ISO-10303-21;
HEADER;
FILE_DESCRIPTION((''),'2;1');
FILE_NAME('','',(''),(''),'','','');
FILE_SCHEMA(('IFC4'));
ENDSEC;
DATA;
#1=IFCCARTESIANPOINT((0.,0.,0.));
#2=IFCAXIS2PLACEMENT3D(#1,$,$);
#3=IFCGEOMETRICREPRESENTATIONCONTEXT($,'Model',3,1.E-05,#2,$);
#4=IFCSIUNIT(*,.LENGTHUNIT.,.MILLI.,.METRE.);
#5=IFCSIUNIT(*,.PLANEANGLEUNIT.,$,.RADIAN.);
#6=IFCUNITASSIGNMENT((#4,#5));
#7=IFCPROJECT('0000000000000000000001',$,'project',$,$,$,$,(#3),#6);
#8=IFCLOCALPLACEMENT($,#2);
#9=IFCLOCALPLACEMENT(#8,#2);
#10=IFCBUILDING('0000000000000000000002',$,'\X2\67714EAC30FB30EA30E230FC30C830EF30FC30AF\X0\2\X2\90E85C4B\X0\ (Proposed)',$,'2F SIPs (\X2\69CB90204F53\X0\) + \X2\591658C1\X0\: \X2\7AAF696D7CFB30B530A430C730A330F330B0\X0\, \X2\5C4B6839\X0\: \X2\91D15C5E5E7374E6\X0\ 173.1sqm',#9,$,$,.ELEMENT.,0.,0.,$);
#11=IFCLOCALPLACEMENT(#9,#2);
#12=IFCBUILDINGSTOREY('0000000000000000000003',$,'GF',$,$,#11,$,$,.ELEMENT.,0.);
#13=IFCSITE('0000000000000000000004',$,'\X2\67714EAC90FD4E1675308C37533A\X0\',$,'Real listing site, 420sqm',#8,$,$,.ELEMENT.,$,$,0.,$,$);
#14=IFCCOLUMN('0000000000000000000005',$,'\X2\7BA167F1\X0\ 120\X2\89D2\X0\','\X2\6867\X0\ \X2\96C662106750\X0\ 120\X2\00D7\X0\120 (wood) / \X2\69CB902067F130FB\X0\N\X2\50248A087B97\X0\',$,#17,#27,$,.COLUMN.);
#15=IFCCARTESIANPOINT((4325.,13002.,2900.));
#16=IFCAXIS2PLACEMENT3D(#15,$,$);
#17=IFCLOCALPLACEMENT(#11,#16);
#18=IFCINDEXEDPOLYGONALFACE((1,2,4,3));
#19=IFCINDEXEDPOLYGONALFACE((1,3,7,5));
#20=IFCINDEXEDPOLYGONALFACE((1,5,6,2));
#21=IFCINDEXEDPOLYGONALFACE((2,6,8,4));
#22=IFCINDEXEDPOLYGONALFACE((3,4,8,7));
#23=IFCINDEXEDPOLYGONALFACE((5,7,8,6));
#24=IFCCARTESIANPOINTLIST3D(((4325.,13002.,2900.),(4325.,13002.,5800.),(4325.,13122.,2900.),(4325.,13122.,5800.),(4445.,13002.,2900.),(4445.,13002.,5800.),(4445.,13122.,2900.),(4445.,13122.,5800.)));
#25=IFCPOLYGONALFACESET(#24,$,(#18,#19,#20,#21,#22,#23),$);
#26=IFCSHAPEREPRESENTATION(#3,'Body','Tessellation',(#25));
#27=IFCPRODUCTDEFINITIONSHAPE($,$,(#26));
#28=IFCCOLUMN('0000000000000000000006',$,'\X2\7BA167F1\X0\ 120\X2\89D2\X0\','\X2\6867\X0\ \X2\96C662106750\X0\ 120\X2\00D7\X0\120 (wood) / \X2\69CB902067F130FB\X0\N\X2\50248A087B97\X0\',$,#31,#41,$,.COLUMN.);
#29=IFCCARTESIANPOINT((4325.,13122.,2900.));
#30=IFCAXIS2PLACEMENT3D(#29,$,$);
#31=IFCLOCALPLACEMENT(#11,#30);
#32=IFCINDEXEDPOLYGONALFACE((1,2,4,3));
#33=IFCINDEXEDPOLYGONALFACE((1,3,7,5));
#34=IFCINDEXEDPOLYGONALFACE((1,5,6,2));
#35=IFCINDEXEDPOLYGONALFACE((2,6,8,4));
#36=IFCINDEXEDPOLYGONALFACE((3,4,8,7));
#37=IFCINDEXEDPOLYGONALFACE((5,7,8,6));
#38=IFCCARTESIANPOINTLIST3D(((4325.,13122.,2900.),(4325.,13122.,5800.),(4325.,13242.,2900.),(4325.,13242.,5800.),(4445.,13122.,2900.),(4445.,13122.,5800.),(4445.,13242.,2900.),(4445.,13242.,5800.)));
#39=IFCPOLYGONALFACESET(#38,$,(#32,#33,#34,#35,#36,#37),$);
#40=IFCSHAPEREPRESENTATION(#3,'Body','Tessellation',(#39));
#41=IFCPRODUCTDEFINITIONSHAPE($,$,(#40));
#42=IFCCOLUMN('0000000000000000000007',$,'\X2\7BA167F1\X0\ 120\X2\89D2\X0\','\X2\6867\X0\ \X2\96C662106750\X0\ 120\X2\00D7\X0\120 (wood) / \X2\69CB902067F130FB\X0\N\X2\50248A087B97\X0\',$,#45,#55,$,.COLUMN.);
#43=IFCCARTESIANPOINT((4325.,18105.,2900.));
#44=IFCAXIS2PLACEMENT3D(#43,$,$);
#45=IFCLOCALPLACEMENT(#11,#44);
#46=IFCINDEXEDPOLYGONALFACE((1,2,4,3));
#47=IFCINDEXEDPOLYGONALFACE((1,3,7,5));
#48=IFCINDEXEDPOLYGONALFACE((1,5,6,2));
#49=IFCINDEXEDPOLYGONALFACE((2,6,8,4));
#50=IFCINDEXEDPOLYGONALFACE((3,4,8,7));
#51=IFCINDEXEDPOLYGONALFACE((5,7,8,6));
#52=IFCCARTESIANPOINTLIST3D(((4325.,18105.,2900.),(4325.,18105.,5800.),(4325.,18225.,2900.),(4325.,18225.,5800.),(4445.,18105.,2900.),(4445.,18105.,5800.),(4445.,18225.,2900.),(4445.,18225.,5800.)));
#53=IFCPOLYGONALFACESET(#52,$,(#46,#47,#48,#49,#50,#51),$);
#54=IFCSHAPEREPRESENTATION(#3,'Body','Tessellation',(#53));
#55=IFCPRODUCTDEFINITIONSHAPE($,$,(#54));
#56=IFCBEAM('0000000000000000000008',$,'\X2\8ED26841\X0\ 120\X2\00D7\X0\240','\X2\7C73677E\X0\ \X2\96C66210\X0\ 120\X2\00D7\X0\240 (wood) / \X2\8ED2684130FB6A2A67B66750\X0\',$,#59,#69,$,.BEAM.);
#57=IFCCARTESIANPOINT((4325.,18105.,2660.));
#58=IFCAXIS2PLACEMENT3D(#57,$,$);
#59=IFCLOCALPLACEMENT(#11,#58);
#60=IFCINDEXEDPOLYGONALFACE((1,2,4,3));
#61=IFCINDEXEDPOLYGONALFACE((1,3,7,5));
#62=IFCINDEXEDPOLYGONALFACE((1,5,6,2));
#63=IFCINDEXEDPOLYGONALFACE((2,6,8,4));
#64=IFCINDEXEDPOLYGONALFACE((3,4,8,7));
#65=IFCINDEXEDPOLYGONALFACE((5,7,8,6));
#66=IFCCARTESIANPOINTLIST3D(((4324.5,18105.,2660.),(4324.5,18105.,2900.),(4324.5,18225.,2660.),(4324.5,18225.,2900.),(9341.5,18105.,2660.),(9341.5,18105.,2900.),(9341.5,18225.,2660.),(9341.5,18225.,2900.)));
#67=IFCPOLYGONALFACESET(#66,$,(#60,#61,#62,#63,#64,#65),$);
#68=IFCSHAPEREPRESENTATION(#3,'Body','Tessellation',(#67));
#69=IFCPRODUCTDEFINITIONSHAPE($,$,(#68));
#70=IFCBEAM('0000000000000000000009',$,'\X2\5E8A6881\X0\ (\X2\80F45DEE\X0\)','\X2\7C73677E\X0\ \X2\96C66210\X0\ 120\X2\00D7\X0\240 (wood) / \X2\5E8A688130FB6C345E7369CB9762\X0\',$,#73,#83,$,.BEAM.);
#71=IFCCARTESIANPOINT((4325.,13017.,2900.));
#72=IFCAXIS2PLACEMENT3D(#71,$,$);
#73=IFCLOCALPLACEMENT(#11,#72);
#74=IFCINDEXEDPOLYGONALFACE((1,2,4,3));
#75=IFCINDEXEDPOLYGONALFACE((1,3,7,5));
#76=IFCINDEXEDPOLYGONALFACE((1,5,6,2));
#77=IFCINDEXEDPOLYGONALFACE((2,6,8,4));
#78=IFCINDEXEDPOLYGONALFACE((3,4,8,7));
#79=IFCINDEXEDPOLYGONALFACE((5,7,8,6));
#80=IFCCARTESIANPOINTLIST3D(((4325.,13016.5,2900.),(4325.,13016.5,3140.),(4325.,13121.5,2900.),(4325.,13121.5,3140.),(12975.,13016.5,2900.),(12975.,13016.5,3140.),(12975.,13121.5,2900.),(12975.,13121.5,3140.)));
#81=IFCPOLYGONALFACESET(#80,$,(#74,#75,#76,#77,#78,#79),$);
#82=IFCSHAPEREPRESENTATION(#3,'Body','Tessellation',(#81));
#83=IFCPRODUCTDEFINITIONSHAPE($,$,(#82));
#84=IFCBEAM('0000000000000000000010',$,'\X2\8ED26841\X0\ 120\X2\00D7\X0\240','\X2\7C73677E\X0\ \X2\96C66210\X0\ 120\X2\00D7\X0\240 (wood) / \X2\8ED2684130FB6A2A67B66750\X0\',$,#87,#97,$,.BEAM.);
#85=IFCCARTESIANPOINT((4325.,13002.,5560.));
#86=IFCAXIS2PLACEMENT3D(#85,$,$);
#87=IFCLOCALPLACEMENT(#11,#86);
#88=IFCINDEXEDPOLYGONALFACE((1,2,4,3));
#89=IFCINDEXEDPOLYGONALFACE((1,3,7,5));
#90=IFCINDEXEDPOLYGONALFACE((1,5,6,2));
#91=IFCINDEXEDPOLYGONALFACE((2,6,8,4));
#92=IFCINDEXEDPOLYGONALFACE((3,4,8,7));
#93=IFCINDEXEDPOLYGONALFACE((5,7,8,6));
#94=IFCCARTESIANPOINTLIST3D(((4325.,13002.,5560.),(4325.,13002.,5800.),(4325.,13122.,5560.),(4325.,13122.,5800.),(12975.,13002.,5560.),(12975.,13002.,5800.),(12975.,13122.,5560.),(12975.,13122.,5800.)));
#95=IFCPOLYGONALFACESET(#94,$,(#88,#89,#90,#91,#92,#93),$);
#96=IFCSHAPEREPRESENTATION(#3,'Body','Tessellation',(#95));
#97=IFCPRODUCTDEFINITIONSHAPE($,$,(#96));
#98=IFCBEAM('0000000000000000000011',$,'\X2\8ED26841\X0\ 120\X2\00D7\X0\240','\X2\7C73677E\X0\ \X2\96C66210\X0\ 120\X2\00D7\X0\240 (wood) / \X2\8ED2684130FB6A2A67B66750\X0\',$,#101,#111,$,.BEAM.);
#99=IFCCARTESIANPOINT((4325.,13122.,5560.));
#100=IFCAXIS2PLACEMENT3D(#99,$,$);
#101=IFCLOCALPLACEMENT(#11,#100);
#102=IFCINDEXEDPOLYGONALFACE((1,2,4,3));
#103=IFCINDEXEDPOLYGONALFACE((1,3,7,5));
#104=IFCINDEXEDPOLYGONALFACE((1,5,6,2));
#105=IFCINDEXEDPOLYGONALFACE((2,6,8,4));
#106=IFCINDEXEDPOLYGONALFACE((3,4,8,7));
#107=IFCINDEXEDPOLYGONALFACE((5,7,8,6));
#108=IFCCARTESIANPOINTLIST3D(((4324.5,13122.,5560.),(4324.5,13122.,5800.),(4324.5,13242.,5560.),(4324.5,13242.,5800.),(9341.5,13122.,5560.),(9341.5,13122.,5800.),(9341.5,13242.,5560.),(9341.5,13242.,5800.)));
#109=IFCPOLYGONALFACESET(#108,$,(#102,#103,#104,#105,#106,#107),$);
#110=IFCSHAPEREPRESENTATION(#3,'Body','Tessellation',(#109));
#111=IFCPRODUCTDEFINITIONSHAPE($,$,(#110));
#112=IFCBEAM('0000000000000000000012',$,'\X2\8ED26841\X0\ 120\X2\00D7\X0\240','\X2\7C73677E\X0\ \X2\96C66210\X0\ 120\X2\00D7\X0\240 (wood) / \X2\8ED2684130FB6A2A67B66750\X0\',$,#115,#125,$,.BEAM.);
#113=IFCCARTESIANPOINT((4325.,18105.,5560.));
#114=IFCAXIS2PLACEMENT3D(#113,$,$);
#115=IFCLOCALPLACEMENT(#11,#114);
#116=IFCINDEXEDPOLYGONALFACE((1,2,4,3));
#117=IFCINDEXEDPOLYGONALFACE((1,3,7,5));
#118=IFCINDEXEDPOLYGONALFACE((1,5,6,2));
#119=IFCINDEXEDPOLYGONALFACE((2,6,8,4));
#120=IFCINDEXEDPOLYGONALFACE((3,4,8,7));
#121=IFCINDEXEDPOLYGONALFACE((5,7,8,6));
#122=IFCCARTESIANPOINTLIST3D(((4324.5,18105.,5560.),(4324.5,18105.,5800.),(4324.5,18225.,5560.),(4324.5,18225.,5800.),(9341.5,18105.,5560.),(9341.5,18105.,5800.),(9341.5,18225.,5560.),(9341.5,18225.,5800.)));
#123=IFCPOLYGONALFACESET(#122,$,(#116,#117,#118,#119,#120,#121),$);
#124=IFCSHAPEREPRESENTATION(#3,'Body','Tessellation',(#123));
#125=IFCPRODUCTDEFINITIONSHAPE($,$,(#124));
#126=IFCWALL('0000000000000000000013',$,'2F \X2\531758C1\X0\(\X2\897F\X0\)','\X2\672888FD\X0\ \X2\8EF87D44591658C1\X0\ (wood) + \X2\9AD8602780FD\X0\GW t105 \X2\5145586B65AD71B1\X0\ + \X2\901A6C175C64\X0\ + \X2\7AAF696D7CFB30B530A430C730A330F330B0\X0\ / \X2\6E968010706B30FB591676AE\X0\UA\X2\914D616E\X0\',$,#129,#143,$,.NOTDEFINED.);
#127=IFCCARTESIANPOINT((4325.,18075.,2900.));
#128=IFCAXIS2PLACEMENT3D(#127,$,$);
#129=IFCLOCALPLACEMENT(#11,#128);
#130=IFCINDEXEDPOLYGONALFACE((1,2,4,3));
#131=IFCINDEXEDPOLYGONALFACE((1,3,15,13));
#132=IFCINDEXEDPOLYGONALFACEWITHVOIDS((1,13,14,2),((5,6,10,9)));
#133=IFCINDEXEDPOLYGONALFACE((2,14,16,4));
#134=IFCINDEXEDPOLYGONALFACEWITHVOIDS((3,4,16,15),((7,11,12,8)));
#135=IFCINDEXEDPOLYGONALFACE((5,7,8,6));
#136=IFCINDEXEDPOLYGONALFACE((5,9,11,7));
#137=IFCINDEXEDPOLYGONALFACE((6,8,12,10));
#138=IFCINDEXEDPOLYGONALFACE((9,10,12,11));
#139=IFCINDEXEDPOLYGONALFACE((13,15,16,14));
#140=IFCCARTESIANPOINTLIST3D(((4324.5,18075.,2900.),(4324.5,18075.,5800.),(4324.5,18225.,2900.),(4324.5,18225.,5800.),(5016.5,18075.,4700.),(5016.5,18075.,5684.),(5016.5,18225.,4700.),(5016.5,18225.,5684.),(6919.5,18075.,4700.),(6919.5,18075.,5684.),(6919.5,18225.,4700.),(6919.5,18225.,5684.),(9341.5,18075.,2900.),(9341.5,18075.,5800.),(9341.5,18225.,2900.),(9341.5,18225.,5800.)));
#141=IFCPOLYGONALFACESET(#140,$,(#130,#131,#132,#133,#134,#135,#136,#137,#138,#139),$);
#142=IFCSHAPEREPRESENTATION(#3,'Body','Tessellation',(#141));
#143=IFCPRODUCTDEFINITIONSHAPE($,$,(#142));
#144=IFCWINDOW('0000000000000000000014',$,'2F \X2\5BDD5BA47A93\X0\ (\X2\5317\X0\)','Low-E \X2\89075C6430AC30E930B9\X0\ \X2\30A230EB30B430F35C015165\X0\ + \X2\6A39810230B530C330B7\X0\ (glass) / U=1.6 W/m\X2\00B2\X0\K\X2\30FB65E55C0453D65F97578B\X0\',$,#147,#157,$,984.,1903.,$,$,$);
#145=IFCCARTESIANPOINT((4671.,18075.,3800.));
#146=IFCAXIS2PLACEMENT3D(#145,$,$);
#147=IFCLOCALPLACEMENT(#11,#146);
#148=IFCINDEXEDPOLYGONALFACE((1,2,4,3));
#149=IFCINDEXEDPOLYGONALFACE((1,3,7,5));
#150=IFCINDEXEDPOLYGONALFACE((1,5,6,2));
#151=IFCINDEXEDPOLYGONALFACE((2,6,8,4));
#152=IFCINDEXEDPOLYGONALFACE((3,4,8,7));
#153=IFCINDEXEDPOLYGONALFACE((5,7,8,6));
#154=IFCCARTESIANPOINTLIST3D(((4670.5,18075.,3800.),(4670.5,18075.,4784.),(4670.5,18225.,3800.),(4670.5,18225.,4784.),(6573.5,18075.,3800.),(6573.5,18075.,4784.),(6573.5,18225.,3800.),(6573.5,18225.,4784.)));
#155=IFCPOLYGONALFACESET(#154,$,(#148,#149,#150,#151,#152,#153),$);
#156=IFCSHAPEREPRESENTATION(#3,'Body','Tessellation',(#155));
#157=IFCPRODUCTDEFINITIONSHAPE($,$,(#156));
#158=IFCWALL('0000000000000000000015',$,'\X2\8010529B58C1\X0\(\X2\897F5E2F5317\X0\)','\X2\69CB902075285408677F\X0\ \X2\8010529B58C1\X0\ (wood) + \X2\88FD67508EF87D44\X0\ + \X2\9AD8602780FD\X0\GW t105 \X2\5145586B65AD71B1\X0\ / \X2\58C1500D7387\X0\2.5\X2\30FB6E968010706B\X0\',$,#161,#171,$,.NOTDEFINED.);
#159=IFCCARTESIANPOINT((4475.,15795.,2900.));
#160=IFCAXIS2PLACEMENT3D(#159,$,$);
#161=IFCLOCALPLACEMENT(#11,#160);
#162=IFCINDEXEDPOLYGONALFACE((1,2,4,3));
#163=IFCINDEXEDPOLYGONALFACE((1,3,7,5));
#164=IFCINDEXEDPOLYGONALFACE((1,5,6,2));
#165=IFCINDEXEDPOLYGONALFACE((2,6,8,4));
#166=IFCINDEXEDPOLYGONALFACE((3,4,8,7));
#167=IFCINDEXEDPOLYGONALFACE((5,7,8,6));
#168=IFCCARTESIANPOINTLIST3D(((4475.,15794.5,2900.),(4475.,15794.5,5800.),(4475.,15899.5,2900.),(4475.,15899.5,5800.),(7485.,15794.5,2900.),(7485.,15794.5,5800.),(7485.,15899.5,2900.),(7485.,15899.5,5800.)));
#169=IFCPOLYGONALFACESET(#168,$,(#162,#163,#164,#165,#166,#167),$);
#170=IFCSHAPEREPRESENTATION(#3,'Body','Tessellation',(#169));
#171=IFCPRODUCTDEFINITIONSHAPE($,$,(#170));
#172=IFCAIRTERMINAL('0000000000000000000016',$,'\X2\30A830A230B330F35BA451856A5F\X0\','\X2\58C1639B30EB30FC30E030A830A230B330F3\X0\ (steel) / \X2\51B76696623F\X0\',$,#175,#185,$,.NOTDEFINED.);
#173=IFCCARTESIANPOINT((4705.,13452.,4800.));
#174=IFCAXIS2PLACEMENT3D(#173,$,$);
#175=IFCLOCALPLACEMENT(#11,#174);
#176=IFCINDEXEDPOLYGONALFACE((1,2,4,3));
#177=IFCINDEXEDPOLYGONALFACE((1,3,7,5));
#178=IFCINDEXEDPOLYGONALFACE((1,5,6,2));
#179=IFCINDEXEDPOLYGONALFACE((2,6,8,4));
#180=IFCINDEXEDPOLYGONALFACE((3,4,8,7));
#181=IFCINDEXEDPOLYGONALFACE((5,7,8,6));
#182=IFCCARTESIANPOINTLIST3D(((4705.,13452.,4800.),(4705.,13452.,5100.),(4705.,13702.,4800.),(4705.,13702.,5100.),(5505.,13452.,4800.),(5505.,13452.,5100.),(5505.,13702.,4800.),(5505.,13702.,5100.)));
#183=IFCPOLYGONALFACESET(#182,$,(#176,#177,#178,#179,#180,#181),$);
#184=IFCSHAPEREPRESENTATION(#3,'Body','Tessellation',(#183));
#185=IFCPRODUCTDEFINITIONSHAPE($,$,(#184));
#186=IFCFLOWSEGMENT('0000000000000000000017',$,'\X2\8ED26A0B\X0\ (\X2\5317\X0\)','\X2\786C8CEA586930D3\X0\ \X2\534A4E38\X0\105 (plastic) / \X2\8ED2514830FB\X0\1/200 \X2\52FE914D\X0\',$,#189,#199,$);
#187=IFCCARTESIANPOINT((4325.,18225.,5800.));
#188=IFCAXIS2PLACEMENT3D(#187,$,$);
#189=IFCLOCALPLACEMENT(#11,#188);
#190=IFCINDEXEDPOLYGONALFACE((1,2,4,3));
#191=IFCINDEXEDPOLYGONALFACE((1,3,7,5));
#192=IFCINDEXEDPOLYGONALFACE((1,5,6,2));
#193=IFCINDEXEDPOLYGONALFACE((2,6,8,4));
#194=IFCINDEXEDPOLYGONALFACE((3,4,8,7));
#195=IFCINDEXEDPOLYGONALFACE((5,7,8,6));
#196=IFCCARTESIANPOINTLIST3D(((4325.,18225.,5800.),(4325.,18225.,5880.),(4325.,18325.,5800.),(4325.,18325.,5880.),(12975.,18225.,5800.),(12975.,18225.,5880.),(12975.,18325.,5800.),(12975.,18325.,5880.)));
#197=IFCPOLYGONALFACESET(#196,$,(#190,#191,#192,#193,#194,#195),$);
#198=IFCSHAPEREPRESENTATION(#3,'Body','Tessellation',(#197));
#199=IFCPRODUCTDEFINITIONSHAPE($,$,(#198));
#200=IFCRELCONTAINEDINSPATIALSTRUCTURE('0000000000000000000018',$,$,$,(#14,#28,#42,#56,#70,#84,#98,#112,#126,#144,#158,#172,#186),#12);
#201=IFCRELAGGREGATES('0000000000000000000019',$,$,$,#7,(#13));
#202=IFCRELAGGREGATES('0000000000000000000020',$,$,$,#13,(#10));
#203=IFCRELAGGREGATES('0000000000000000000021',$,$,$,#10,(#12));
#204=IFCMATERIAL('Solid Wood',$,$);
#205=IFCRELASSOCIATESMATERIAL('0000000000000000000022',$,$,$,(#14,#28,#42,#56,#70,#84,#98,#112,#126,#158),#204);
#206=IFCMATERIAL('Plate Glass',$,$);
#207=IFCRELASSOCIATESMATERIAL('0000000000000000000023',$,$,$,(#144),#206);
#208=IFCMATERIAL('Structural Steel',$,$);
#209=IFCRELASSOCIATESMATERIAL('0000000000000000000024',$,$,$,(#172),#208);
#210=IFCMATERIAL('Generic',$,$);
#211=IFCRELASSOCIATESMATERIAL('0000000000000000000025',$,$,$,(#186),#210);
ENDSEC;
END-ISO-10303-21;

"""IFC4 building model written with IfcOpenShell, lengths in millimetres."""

from ifc_helpers import new_model, si_unit, frame, frame_2d, origin, place, context, project, spatial, rectangle, extrude, material, element, fill, save


model = new_model("IFC4")

# Units and contexts
model_context = context("Model", 3, precision=1e-05, world=origin())
ifc_project = project(units=[si_unit("LENGTHUNIT", "METRE", prefix="MILLI"), si_unit("PLANEANGLEUNIT", "RADIAN")], contexts=[model_context])

# Site, building, storey
site_placement = place(None, origin())
site = spatial("IfcSite", under=ifc_project, at=site_placement, Name="東京都世田谷区", ObjectType="Real listing site, 420sqm", CompositionType="ELEMENT", RefElevation=0.0)
building_placement = place(site_placement, origin())
building = spatial("IfcBuilding", under=site, at=building_placement, Name="東京・リモートワーク2部屋 (Proposed)", ObjectType="2F SIPs (構造体) + 外壁: 窯業系サイディング, 屋根: 金属平瓦 173.1sqm", CompositionType="ELEMENT", ElevationOfRefHeight=0.0, ElevationOfTerrain=0.0)
storey_placement = place(building_placement, origin())
storey = spatial("IfcBuildingStorey", under=building, at=storey_placement, Name="GF", CompositionType="ELEMENT", Elevation=0.0)

# Columns
ifc_material_1 = material(Name="Solid Wood")
column_1_placement = place(storey_placement, frame((4325.0, 13002.0, 2900.0)))
element("IfcColumn", 1, at=column_1_placement, inside=storey, material=ifc_material_1, Name="管柱 120角", Description="桧 集成材 120×120 (wood) / 構造柱・N値計算", PredefinedType="COLUMN", context=model_context, shape_type="SweptSolid", body=[
    extrude(rectangle(XDim=120.0, YDim=120.0, at=frame_2d((60.0, 60.0))), frame((4325.0, 13002.0, 2900.0)), (0.0, 0.0, 1.0), 2900.0),
])
column_2_placement = place(storey_placement, frame((4325.0, 13122.0, 2900.0)))
element("IfcColumn", 2, at=column_2_placement, inside=storey, material=ifc_material_1, Name="管柱 120角", Description="桧 集成材 120×120 (wood) / 構造柱・N値計算", PredefinedType="COLUMN", context=model_context, shape_type="SweptSolid", body=[
    extrude(rectangle(XDim=120.0, YDim=120.0, at=frame_2d((60.0, 60.0))), frame((4325.0, 13122.0, 2900.0)), (0.0, 0.0, 1.0), 2900.0),
])
column_3_placement = place(storey_placement, frame((4325.0, 18105.0, 2900.0)))
element("IfcColumn", 3, at=column_3_placement, inside=storey, material=ifc_material_1, Name="管柱 120角", Description="桧 集成材 120×120 (wood) / 構造柱・N値計算", PredefinedType="COLUMN", context=model_context, shape_type="SweptSolid", body=[
    extrude(rectangle(XDim=120.0, YDim=120.0, at=frame_2d((60.0, 60.0))), frame((4325.0, 18105.0, 2900.0)), (0.0, 0.0, 1.0), 2900.0),
])

# Beams
beam_1_placement = place(storey_placement, frame((4325.0, 18105.0, 2660.0)))
element("IfcBeam", 4, at=beam_1_placement, inside=storey, material=ifc_material_1, Name="軒桁 120×240", Description="米松 集成 120×240 (wood) / 軒桁・横架材", PredefinedType="BEAM", context=model_context, shape_type="SweptSolid", body=[
    extrude(rectangle(XDim=5017.0, YDim=120.0, at=frame_2d((2508.0, 60.0))), frame((4325.0, 18105.0, 2660.0)), (0.0, 0.0, 1.0), 240.0),
])
beam_2_placement = place(storey_placement, frame((4325.0, 13017.0, 2900.0)))
element("IfcBeam", 5, at=beam_2_placement, inside=storey, material=ifc_material_1, Name="床梁 (胴差)", Description="米松 集成 120×240 (wood) / 床梁・水平構面", PredefinedType="BEAM", context=model_context, shape_type="SweptSolid", body=[
    extrude(rectangle(XDim=8650.0, YDim=105.0, at=frame_2d((4325.0, 52.0))), frame((4325.0, 13017.0, 2900.0)), (0.0, 0.0, 1.0), 240.0),
])
beam_3_placement = place(storey_placement, frame((4325.0, 13002.0, 5560.0)))
element("IfcBeam", 6, at=beam_3_placement, inside=storey, material=ifc_material_1, Name="軒桁 120×240", Description="米松 集成 120×240 (wood) / 軒桁・横架材", PredefinedType="BEAM", context=model_context, shape_type="SweptSolid", body=[
    extrude(rectangle(XDim=8650.0, YDim=120.0, at=frame_2d((4325.0, 60.0))), frame((4325.0, 13002.0, 5560.0)), (0.0, 0.0, 1.0), 240.0),
])
beam_4_placement = place(storey_placement, frame((4325.0, 13122.0, 5560.0)))
element("IfcBeam", 7, at=beam_4_placement, inside=storey, material=ifc_material_1, Name="軒桁 120×240", Description="米松 集成 120×240 (wood) / 軒桁・横架材", PredefinedType="BEAM", context=model_context, shape_type="SweptSolid", body=[
    extrude(rectangle(XDim=5017.0, YDim=120.0, at=frame_2d((2508.0, 60.0))), frame((4325.0, 13122.0, 5560.0)), (0.0, 0.0, 1.0), 240.0),
])
beam_5_placement = place(storey_placement, frame((4325.0, 18105.0, 5560.0)))
element("IfcBeam", 8, at=beam_5_placement, inside=storey, material=ifc_material_1, Name="軒桁 120×240", Description="米松 集成 120×240 (wood) / 軒桁・横架材", PredefinedType="BEAM", context=model_context, shape_type="SweptSolid", body=[
    extrude(rectangle(XDim=5017.0, YDim=120.0, at=frame_2d((2508.0, 60.0))), frame((4325.0, 18105.0, 5560.0)), (0.0, 0.0, 1.0), 240.0),
])

# Wall, opening, window
wall_1_placement = place(storey_placement, frame((4325.0, 18075.0, 2900.0)))
wall_1 = element("IfcWall", 9, at=wall_1_placement, inside=storey, material=ifc_material_1, Name="2F 北壁(西)", Description="木製 軸組外壁 (wood) + 高性能GW t105 充填断熱 + 通気層 + 窯業系サイディング / 準耐火・外皮UA配慮", PredefinedType="NOTDEFINED", context=model_context, shape_type="SweptSolid", body=[
    extrude(rectangle(XDim=5017.0, YDim=150.0, at=frame_2d((2508.0, 75.0))), frame((4325.0, 18075.0, 2900.0)), (0.0, 0.0, 1.0), 2900.0),
])
opening_placement = place(storey_placement, frame((4671.0, 18075.0, 3800.0)))
opening = element("IfcOpeningElement", 10, at=opening_placement, cuts=wall_1, PredefinedType="NOTDEFINED", context=model_context, shape_type="SweptSolid", body=[
    extrude(rectangle(XDim=1903.0, YDim=150.0, at=frame_2d((951.0, 75.0))), frame((4671.0, 18075.0, 3800.0)), (0.0, 0.0, 1.0), 984.0),
])
ifc_material_2 = material(Name="Plate Glass")
window_placement = place(storey_placement, frame((4671.0, 18075.0, 3800.0)))
window = element("IfcWindow", 11, at=window_placement, inside=storey, material=ifc_material_2, Name="2F 寝室窓 (北)", Description="Low-E 複層ガラス アルゴン封入 + 樹脂サッシ (glass) / U=1.6 W/m²K・日射取得型", OverallHeight=984.0, OverallWidth=1903.0, context=model_context, shape_type="SweptSolid", body=[
    extrude(rectangle(XDim=1903.0, YDim=150.0, at=frame_2d((951.0, 75.0))), frame((4671.0, 18075.0, 3800.0)), (0.0, 0.0, 1.0), 984.0),
])
fill(opening, window)

# Wall
wall_2_placement = place(storey_placement, frame((4475.0, 15795.0, 2900.0)))
element("IfcWall", 12, at=wall_2_placement, inside=storey, material=ifc_material_1, Name="耐力壁(西帯北)", Description="構造用合板 耐力壁 (wood) + 製材軸組 + 高性能GW t105 充填断熱 / 壁倍率2.5・準耐火", PredefinedType="NOTDEFINED", context=model_context, shape_type="SweptSolid", body=[
    extrude(rectangle(XDim=3010.0, YDim=105.0, at=frame_2d((1505.0, 52.0))), frame((4475.0, 15795.0, 2900.0)), (0.0, 0.0, 1.0), 2900.0),
])

# Shared definitions
ifc_material_3 = material(Name="Structural Steel")

# Shared definitions
ifc_material_4 = material(Name="Generic")

# Air terminal
air_terminal_placement = place(storey_placement, frame((4705.0, 13452.0, 4800.0)))
element("IfcAirTerminal", 13, at=air_terminal_placement, inside=storey, material=ifc_material_3, Name="エアコン室内機", Description="壁掛ルームエアコン (steel) / 冷暖房", PredefinedType="NOTDEFINED", context=model_context, shape_type="SweptSolid", body=[
    extrude(rectangle(XDim=800.0, YDim=250.0, at=frame_2d((400.0, 125.0))), frame((4705.0, 13452.0, 4800.0)), (0.0, 0.0, 1.0), 300.0),
])

# Flow segment
flow_segment_placement = place(storey_placement, frame((4325.0, 18225.0, 5800.0)))
element("IfcFlowSegment", 14, at=flow_segment_placement, inside=storey, material=ifc_material_4, Name="軒樋 (北)", Description="硬質塩ビ 半丸105 (plastic) / 軒先・1/200 勾配", context=model_context, shape_type="SweptSolid", body=[
    extrude(rectangle(XDim=8650.0, YDim=100.0, at=frame_2d((4325.0, 50.0))), frame((4325.0, 18225.0, 5800.0)), (0.0, 0.0, 1.0), 80.0),
])

save(model, "model.ifc")
